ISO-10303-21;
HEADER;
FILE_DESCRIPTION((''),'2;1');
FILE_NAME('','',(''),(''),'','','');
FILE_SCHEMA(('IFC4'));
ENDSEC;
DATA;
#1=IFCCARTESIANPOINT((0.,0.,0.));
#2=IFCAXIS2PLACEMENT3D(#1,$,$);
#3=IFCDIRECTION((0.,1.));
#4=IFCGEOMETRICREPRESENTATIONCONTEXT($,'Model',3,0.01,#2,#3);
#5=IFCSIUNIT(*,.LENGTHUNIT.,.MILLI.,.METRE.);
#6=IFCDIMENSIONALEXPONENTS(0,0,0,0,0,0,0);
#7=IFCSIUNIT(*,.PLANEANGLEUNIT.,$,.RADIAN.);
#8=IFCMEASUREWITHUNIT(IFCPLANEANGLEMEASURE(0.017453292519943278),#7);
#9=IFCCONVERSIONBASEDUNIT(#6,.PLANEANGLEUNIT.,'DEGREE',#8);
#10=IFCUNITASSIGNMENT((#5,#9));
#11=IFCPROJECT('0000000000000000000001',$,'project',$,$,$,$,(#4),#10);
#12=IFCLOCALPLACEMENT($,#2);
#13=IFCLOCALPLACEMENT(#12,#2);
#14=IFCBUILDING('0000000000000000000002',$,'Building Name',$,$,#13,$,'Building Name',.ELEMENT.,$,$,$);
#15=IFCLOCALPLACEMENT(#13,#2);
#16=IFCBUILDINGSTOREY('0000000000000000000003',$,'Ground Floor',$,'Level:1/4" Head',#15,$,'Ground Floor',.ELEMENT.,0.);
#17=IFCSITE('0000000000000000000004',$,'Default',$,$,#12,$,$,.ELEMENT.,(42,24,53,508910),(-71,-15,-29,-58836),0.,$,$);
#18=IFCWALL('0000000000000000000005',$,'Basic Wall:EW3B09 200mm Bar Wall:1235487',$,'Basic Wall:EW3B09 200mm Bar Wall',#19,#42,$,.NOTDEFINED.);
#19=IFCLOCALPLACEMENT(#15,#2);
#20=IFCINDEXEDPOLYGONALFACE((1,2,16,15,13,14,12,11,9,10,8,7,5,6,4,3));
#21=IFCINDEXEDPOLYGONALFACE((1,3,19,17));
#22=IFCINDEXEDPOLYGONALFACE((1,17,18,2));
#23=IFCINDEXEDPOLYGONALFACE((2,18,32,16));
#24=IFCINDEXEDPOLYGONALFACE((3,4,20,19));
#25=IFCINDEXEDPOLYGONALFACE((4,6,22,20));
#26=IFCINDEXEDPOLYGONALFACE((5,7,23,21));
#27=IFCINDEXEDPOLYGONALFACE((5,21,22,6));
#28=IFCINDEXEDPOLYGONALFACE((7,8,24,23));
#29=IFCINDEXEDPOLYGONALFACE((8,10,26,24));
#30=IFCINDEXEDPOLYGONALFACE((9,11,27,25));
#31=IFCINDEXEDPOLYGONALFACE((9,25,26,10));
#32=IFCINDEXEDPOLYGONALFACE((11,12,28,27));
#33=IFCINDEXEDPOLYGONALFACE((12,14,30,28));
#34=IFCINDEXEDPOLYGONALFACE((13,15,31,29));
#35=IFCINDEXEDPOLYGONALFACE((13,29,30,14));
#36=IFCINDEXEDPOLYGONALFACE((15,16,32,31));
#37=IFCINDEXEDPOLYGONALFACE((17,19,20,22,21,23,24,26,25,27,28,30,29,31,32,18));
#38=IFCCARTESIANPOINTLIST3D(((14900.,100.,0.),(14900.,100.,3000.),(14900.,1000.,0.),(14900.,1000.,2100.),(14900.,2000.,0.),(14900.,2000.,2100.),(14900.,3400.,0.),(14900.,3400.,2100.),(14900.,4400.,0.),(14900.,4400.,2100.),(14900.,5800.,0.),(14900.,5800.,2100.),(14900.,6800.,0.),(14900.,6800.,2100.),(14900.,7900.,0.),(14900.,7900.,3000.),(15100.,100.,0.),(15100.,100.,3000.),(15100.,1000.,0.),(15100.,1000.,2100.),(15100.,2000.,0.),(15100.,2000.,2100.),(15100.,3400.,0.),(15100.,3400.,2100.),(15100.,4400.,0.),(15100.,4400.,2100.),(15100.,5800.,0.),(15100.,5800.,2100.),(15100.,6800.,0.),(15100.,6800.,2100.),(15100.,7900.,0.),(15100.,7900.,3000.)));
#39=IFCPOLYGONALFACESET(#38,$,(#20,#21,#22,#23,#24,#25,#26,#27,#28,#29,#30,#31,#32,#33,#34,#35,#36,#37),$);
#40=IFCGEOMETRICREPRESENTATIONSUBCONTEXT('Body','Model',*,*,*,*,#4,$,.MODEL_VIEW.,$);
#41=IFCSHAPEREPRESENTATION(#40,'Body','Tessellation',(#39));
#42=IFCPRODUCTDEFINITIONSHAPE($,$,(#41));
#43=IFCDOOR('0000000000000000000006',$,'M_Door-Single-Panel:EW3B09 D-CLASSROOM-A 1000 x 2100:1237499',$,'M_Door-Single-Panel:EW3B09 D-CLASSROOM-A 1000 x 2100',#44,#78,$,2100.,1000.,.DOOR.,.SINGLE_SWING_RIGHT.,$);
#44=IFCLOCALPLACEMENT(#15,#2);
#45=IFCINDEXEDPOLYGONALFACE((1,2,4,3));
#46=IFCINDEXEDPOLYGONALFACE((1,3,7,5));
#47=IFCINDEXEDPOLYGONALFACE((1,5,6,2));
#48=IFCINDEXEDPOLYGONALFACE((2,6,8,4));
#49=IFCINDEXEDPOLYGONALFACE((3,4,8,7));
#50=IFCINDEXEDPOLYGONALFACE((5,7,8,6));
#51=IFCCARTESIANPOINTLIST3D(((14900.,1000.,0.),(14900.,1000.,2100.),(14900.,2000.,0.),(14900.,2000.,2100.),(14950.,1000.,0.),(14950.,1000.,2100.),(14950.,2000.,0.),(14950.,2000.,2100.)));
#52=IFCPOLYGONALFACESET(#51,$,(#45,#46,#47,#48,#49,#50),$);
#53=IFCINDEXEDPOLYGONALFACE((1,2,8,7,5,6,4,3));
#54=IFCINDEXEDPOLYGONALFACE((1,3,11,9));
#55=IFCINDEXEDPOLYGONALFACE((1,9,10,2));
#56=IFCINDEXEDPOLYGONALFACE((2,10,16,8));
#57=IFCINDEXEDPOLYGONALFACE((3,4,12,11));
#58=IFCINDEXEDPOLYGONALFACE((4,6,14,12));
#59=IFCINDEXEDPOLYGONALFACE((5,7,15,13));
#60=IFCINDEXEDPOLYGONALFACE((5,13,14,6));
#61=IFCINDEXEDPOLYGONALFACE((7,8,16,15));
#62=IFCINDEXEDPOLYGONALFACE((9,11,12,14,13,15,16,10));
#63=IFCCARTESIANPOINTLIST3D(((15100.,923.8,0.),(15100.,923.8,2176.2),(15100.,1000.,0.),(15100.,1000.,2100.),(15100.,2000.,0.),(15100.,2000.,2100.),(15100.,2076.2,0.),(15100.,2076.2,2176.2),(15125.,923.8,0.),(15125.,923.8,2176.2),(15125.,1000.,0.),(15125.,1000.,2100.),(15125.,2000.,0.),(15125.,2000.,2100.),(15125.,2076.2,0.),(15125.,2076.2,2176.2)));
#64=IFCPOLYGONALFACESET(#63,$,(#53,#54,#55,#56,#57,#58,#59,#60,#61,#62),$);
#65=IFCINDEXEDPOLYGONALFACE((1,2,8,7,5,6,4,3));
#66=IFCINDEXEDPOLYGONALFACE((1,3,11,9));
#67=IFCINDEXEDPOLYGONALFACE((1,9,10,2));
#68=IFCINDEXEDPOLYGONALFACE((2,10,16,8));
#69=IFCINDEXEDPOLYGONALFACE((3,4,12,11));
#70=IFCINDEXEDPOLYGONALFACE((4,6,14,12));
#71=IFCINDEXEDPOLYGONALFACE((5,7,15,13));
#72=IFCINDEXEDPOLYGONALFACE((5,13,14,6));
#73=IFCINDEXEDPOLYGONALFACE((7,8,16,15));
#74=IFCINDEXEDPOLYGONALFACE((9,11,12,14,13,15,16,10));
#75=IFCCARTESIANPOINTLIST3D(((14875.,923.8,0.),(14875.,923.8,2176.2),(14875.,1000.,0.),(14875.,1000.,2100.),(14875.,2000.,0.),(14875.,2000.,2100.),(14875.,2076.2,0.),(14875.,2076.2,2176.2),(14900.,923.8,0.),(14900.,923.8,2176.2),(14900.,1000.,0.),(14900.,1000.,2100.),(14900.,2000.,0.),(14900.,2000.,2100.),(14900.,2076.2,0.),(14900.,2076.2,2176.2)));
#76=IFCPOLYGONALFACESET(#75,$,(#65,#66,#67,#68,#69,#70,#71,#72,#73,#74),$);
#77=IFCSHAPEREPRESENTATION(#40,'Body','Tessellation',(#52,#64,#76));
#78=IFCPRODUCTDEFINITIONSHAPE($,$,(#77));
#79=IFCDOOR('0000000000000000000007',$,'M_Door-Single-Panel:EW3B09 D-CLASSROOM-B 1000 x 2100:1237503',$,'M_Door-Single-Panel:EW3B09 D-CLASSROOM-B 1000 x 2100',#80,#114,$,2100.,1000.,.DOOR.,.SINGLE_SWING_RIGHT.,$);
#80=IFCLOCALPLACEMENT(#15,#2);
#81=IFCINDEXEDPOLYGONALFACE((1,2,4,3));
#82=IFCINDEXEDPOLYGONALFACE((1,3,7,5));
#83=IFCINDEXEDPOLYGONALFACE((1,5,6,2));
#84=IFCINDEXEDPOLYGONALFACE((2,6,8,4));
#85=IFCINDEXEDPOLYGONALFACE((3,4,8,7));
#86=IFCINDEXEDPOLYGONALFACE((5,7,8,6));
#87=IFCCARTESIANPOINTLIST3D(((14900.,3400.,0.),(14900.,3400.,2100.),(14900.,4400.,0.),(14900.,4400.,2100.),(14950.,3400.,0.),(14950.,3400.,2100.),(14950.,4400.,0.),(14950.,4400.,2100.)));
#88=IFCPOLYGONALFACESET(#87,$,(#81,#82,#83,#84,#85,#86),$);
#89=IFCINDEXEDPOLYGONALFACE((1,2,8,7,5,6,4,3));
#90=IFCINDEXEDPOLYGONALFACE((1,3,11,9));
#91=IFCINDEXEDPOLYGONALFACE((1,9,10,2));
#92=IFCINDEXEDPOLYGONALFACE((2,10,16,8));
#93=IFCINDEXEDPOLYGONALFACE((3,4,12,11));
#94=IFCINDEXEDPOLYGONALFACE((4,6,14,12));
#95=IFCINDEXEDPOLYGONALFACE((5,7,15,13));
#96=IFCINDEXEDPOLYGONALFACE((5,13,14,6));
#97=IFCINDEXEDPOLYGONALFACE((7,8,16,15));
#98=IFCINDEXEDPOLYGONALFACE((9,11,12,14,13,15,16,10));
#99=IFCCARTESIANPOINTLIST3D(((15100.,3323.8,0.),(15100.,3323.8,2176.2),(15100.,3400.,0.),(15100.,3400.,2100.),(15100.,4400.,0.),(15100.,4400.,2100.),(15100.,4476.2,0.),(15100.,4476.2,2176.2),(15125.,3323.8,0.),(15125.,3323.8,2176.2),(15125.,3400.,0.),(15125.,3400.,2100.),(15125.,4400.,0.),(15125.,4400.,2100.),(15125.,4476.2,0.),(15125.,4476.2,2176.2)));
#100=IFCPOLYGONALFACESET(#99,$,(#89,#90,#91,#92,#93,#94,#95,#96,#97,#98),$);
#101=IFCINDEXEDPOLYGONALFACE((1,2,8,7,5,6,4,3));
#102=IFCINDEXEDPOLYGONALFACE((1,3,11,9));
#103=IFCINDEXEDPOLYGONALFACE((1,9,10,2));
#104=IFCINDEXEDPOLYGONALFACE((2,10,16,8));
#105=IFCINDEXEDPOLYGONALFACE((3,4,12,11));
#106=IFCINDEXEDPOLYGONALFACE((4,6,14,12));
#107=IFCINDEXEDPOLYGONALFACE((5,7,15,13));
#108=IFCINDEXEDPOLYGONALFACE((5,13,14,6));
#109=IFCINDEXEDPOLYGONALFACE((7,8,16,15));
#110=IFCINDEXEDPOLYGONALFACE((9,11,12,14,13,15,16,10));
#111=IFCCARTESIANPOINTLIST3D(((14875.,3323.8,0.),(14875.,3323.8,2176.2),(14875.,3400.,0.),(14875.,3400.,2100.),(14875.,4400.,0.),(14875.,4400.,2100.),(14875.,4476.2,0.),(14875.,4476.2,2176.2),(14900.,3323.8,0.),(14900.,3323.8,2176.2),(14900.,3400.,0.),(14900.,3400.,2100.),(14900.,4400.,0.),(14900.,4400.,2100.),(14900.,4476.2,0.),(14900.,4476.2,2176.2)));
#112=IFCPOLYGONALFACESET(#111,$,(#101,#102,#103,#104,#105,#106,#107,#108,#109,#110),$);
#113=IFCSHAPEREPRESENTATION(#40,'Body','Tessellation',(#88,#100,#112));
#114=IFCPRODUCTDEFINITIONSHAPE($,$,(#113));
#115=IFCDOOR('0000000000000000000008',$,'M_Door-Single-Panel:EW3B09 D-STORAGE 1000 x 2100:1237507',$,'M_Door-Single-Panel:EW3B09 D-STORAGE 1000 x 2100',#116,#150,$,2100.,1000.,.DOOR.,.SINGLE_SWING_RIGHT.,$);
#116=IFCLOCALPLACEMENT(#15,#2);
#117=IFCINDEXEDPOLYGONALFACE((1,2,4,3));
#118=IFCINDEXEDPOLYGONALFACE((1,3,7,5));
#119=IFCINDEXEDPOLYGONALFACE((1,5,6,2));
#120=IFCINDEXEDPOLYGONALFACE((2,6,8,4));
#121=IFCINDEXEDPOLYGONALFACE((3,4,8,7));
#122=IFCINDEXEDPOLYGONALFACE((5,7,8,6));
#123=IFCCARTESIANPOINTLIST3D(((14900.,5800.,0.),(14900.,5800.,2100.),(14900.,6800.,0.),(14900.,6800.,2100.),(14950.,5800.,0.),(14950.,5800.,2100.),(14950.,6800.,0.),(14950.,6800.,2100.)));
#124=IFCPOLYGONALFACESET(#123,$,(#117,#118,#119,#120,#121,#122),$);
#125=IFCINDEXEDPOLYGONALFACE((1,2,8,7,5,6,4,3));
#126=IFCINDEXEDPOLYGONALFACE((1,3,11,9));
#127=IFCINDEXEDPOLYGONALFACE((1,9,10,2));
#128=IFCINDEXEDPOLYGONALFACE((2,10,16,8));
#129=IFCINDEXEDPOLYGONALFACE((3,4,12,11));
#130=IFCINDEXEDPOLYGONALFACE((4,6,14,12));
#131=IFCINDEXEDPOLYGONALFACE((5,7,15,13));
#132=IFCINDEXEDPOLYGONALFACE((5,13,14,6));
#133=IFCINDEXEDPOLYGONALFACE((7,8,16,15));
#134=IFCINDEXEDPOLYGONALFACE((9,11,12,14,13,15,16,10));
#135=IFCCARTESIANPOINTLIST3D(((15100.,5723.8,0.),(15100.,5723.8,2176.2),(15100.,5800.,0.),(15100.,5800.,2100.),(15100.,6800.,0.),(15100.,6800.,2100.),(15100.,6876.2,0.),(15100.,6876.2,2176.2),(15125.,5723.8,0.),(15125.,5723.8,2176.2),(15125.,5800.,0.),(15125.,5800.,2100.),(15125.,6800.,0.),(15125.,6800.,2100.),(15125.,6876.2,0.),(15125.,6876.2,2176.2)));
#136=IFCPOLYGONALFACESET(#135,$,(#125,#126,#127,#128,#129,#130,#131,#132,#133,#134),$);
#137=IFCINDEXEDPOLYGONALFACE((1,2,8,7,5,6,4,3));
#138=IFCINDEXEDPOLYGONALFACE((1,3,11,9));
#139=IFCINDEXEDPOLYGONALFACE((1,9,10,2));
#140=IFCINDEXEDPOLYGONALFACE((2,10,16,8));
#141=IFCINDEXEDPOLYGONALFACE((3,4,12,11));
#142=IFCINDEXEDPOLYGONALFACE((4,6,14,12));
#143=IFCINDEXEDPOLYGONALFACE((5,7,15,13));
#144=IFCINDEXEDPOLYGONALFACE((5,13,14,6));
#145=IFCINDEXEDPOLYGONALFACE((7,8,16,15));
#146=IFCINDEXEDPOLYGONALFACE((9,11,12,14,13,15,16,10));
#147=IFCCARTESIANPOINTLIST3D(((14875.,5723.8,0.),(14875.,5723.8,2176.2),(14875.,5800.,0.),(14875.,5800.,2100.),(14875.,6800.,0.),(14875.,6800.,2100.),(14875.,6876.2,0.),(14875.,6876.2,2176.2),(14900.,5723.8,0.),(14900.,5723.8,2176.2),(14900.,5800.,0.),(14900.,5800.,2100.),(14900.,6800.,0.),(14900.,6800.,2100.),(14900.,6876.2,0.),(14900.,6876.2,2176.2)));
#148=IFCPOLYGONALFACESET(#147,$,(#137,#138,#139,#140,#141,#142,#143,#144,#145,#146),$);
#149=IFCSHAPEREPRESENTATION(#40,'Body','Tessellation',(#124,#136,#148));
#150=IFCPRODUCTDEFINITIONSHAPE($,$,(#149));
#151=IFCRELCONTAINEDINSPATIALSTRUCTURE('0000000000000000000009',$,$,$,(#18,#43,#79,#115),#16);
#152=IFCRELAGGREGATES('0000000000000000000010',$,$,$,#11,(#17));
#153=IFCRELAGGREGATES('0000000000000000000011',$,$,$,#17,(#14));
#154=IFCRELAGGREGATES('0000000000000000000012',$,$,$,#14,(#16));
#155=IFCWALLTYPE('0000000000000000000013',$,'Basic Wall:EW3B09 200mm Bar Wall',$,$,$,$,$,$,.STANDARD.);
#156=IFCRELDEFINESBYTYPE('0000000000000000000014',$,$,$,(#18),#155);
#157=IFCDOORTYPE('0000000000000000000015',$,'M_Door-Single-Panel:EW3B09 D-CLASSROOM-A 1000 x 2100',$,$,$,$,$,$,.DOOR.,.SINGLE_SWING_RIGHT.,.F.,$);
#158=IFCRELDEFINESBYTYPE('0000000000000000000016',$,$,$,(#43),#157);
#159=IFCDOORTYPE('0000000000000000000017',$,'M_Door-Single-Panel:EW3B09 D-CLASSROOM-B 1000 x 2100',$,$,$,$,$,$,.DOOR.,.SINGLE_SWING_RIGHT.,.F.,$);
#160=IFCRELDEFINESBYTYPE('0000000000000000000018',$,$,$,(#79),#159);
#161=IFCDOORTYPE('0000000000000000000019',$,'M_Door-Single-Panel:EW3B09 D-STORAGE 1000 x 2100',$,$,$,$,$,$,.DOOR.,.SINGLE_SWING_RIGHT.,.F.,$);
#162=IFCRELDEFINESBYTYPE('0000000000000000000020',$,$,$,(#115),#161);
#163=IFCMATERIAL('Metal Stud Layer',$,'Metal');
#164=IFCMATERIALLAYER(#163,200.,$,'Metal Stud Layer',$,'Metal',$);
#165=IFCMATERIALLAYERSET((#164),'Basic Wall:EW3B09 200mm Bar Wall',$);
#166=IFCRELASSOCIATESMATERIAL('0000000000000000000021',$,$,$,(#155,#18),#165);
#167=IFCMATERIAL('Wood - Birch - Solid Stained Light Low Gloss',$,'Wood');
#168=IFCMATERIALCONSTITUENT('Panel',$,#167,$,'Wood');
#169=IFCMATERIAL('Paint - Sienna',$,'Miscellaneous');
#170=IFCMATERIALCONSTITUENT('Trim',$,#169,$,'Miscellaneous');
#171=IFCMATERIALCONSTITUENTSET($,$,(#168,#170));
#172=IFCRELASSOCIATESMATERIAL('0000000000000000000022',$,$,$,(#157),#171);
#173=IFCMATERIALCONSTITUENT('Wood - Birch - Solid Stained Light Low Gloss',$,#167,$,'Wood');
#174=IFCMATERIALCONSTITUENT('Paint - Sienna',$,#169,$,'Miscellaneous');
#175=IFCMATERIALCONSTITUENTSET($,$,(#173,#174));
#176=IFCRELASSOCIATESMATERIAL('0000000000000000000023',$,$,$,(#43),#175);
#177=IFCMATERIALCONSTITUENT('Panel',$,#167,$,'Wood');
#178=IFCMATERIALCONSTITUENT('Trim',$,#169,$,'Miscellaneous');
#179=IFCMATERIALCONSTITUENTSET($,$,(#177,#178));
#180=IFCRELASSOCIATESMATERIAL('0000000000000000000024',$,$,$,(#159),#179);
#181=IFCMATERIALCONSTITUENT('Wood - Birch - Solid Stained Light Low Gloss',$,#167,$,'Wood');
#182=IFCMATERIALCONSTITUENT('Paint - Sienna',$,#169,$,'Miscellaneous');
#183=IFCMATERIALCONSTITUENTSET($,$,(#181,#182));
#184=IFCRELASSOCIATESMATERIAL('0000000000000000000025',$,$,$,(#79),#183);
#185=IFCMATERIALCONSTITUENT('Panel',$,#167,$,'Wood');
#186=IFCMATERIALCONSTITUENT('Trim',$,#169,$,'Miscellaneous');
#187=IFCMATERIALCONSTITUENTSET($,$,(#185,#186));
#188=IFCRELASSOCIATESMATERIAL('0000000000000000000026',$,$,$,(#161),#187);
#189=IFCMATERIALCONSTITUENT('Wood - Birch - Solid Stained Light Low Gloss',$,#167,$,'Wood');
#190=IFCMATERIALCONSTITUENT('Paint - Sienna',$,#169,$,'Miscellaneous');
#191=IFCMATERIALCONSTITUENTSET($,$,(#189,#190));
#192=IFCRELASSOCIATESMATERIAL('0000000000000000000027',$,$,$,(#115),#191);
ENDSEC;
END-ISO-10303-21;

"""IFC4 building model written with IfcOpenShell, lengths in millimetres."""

from ifc_helpers import new_model, entity, si_unit, converted_unit, direction, frame, frame_2d, origin, place, context, subcontext, project, spatial, polyline, rectangle, outline, extrude, source, transform, mapped, material, layer, layer_set, layer_usage, constituent, constituent_set, type_object, type_shapes, element, fill, save


model = new_model("IFC4")

# Units and contexts
model_context = context("Model", 3, precision=0.01, world=origin(), true_north=direction((0.0, 1.0)))
body_context = subcontext(model_context, "Body", "Model", "MODEL_VIEW")
ifc_project = project(units=[si_unit("LENGTHUNIT", "METRE", prefix="MILLI"), converted_unit("PLANEANGLEUNIT", "DEGREE", entity("IfcPlaneAngleMeasure", 0.017453292519943278), si_unit("PLANEANGLEUNIT", "RADIAN"), dimensions=[0, 0, 0, 0, 0, 0, 0])], contexts=[model_context])

# Site, building, storey
site_placement = place(None, origin())
site = spatial("IfcSite", under=ifc_project, at=site_placement, Name="Default", CompositionType="ELEMENT", RefLatitude=(42, 24, 53, 508910), RefLongitude=(-71, -15, -29, -58836), RefElevation=0.0)
building_placement = place(site_placement, origin())
building = spatial("IfcBuilding", under=site, at=building_placement, Name="Building Name", LongName="Building Name", CompositionType="ELEMENT")
storey_placement = place(building_placement, origin())
storey = spatial("IfcBuildingStorey", under=building, at=storey_placement, Name="Ground Floor", ObjectType="Level:1/4\" Head", LongName="Ground Floor", CompositionType="ELEMENT", Elevation=0.0)

# Shared definitions
ifc_material_1 = material(Name="Metal Stud Layer", Category="Metal")
ifc_layer_1 = layer(ifc_material_1, 200.0, Name="Metal Stud Layer", Category="Metal")
ifc_layer_set_1 = layer_set([ifc_layer_1], Name="Basic Wall:EW3B09 200mm Bar Wall")
wall_type = type_object("IfcWallType", Name="Basic Wall:EW3B09 200mm Bar Wall", PredefinedType="STANDARD", material=ifc_layer_set_1)
ifc_material_2 = material(Name="Wood - Birch - Solid Stained Light Low Gloss", Category="Wood")
ifc_material_3 = material(Name="Paint - Sienna", Category="Miscellaneous")

# Wall, openings, doors
ifc_layer_usage_1 = layer_usage(ifc_layer_set_1, "AXIS2", "NEGATIVE", 100.0)
wall_1_placement = place(storey_placement, frame((15000.0, 100.0, 0.0), z_axis=(0.0, 0.0, 1.0), x_axis=(0.0, 1.0, 0.0)))
wall_1 = element("IfcWall", 1, at=wall_1_placement, inside=storey, type_object=wall_type, material=ifc_layer_usage_1, Name="Basic Wall:EW3B09 200mm Bar Wall:1235487", ObjectType="Basic Wall:EW3B09 200mm Bar Wall", PredefinedType="NOTDEFINED", context=body_context, shape_type="SweptSolid", body=[
    extrude(rectangle(XDim=7800.0, YDim=200.0, at=frame_2d((3900.0, 0.0), x_axis=(1.0, 0.0))), origin(), (0.0, 0.0, 1.0), 3000.0),
])
opening_1_placement = place(wall_1_placement, frame((900.0, -100.0, 0.0)))
opening_1 = element("IfcOpeningElement", 2, at=opening_1_placement, cuts=wall_1, PredefinedType="OPENING", context=body_context, shape_type="SweptSolid", body=[
    extrude(rectangle(XDim=1000.0, YDim=2100.0, at=frame_2d((1050.0, 500.0), x_axis=(0.0, 1.0))), frame((0.0, 0.0, 0.0), z_axis=(0.0, 1.0, 0.0), x_axis=(0.0, 0.0, 1.0)), (0.0, 0.0, 1.0), 200.0),
])
opening_2_placement = place(wall_1_placement, frame((3300.0, -100.0, 0.0)))
opening_2 = element("IfcOpeningElement", 3, at=opening_2_placement, cuts=wall_1, PredefinedType="OPENING", context=body_context, shape_type="SweptSolid", body=[
    extrude(rectangle(XDim=1000.0, YDim=2100.0, at=frame_2d((1050.0, 500.0), x_axis=(0.0, 1.0))), frame((0.0, 0.0, 0.0), z_axis=(0.0, 1.0, 0.0), x_axis=(0.0, 0.0, 1.0)), (0.0, 0.0, 1.0), 200.0),
])
opening_3_placement = place(wall_1_placement, frame((5700.0, -100.0, 0.0)))
opening_3 = element("IfcOpeningElement", 4, at=opening_3_placement, cuts=wall_1, PredefinedType="OPENING", context=body_context, shape_type="SweptSolid", body=[
    extrude(rectangle(XDim=1000.0, YDim=2100.0, at=frame_2d((1050.0, 500.0), x_axis=(0.0, 1.0))), frame((0.0, 0.0, 0.0), z_axis=(0.0, 1.0, 0.0), x_axis=(0.0, 0.0, 1.0)), (0.0, 0.0, 1.0), 200.0),
])
ifc_constituent_1 = constituent(ifc_material_2, Name="Wood - Birch - Solid Stained Light Low Gloss", Category="Wood")
ifc_constituent_2 = constituent(ifc_material_3, Name="Paint - Sienna", Category="Miscellaneous")
ifc_constituent_set_1 = constituent_set(constituents=[ifc_constituent_1, ifc_constituent_2])
ifc_constituent_3 = constituent(ifc_material_2, Name="Panel", Category="Wood")
ifc_constituent_4 = constituent(ifc_material_3, Name="Trim", Category="Miscellaneous")
ifc_constituent_set_2 = constituent_set(constituents=[ifc_constituent_3, ifc_constituent_4])
door_type_1 = type_object("IfcDoorType", Name="M_Door-Single-Panel:EW3B09 D-CLASSROOM-A 1000 x 2100", OperationType="SINGLE_SWING_RIGHT", ParameterTakesPrecedence=False, PredefinedType="DOOR", material=ifc_constituent_set_2)
shared_shape_1 = source(origin(), body_context, "Body", "SweptSolid", [
    extrude(rectangle(XDim=50.0, YDim=1000.0, at=frame_2d((0.0, 0.0), x_axis=(1.0, 0.0))), frame((500.0, 175.0, 0.0), z_axis=(0.0, 0.0, 1.0), x_axis=(0.0, 1.0, 0.0)), (0.0, 0.0, 1.0), 2100.0),
    extrude(outline(polyline([(-1107.1, -576.2), (1069.0, -576.2), (1069.0, -500.0), (-1030.9, -500.0), (-1030.9, 500.0), (1069.0, 500.0), (1069.0, 576.2), (-1107.1, 576.2), (-1107.1, -576.2)])), frame((500.0, -25.0, 1069.0), z_axis=(0.0, 1.0, 0.0), x_axis=(0.0, 0.0, -1.0)), (0.0, 0.0, 1.0), 25.0),
    extrude(outline(polyline([(-576.2, -1107.1), (576.2, -1107.1), (576.2, 1069.1), (500.0, 1069.1), (500.0, -1031.0), (-500.0, -1031.0), (-500.0, 1069.1), (-576.2, 1069.1), (-576.2, -1107.1)])), frame((500.0, 200.0, 1069.1), z_axis=(0.0, 1.0, 0.0), x_axis=(1.0, 0.0, 0.0)), (0.0, 0.0, 1.0), 25.0),
])
type_shapes(door_type_1, [shared_shape_1])
door_1_placement = place(opening_1_placement, origin())
door_1 = element("IfcDoor", 5, at=door_1_placement, inside=storey, type_object=door_type_1, material=ifc_constituent_set_1, Name="M_Door-Single-Panel:EW3B09 D-CLASSROOM-A 1000 x 2100:1237499", ObjectType="M_Door-Single-Panel:EW3B09 D-CLASSROOM-A 1000 x 2100", OperationType="SINGLE_SWING_RIGHT", OverallHeight=2100.0, OverallWidth=1000.0, PredefinedType="DOOR", context=body_context, shape_type="MappedRepresentation", body=[
    mapped(shared_shape_1, transform((0.0, 0.0, 0.0), scale=1.0)),
])
fill(opening_1, door_1)
ifc_constituent_5 = constituent(ifc_material_2, Name="Wood - Birch - Solid Stained Light Low Gloss", Category="Wood")
ifc_constituent_6 = constituent(ifc_material_3, Name="Paint - Sienna", Category="Miscellaneous")
ifc_constituent_set_3 = constituent_set(constituents=[ifc_constituent_5, ifc_constituent_6])
ifc_constituent_7 = constituent(ifc_material_2, Name="Panel", Category="Wood")
ifc_constituent_8 = constituent(ifc_material_3, Name="Trim", Category="Miscellaneous")
ifc_constituent_set_4 = constituent_set(constituents=[ifc_constituent_7, ifc_constituent_8])
door_type_2 = type_object("IfcDoorType", Name="M_Door-Single-Panel:EW3B09 D-CLASSROOM-B 1000 x 2100", OperationType="SINGLE_SWING_RIGHT", ParameterTakesPrecedence=False, PredefinedType="DOOR", material=ifc_constituent_set_4)
shared_shape_2 = source(origin(), body_context, "Body", "SweptSolid", [
    extrude(rectangle(XDim=50.0, YDim=1000.0, at=frame_2d((0.0, 0.0), x_axis=(1.0, 0.0))), frame((500.0, 175.0, 0.0), z_axis=(0.0, 0.0, 1.0), x_axis=(0.0, 1.0, 0.0)), (0.0, 0.0, 1.0), 2100.0),
    extrude(outline(polyline([(-1107.1, -576.2), (1069.0, -576.2), (1069.0, -500.0), (-1030.9, -500.0), (-1030.9, 500.0), (1069.0, 500.0), (1069.0, 576.2), (-1107.1, 576.2), (-1107.1, -576.2)])), frame((500.0, -25.0, 1069.0), z_axis=(0.0, 1.0, 0.0), x_axis=(0.0, 0.0, -1.0)), (0.0, 0.0, 1.0), 25.0),
    extrude(outline(polyline([(-576.2, -1107.1), (576.2, -1107.1), (576.2, 1069.1), (500.0, 1069.1), (500.0, -1031.0), (-500.0, -1031.0), (-500.0, 1069.1), (-576.2, 1069.1), (-576.2, -1107.1)])), frame((500.0, 200.0, 1069.1), z_axis=(0.0, 1.0, 0.0), x_axis=(1.0, 0.0, 0.0)), (0.0, 0.0, 1.0), 25.0),
])
type_shapes(door_type_2, [shared_shape_2])
door_2_placement = place(opening_2_placement, origin())
door_2 = element("IfcDoor", 6, at=door_2_placement, inside=storey, type_object=door_type_2, material=ifc_constituent_set_3, Name="M_Door-Single-Panel:EW3B09 D-CLASSROOM-B 1000 x 2100:1237503", ObjectType="M_Door-Single-Panel:EW3B09 D-CLASSROOM-B 1000 x 2100", OperationType="SINGLE_SWING_RIGHT", OverallHeight=2100.0, OverallWidth=1000.0, PredefinedType="DOOR", context=body_context, shape_type="MappedRepresentation", body=[
    mapped(shared_shape_2, transform((0.0, 0.0, 0.0), scale=1.0)),
])
fill(opening_2, door_2)
ifc_constituent_9 = constituent(ifc_material_2, Name="Wood - Birch - Solid Stained Light Low Gloss", Category="Wood")
ifc_constituent_10 = constituent(ifc_material_3, Name="Paint - Sienna", Category="Miscellaneous")
ifc_constituent_set_5 = constituent_set(constituents=[ifc_constituent_9, ifc_constituent_10])
ifc_constituent_11 = constituent(ifc_material_2, Name="Panel", Category="Wood")
ifc_constituent_12 = constituent(ifc_material_3, Name="Trim", Category="Miscellaneous")
ifc_constituent_set_6 = constituent_set(constituents=[ifc_constituent_11, ifc_constituent_12])
door_type_3 = type_object("IfcDoorType", Name="M_Door-Single-Panel:EW3B09 D-STORAGE 1000 x 2100", OperationType="SINGLE_SWING_RIGHT", ParameterTakesPrecedence=False, PredefinedType="DOOR", material=ifc_constituent_set_6)
shared_shape_3 = source(origin(), body_context, "Body", "SweptSolid", [
    extrude(rectangle(XDim=50.0, YDim=1000.0, at=frame_2d((0.0, 0.0), x_axis=(1.0, 0.0))), frame((500.0, 175.0, 0.0), z_axis=(0.0, 0.0, 1.0), x_axis=(0.0, 1.0, 0.0)), (0.0, 0.0, 1.0), 2100.0),
    extrude(outline(polyline([(-1107.1, -576.2), (1069.0, -576.2), (1069.0, -500.0), (-1030.9, -500.0), (-1030.9, 500.0), (1069.0, 500.0), (1069.0, 576.2), (-1107.1, 576.2), (-1107.1, -576.2)])), frame((500.0, -25.0, 1069.0), z_axis=(0.0, 1.0, 0.0), x_axis=(0.0, 0.0, -1.0)), (0.0, 0.0, 1.0), 25.0),
    extrude(outline(polyline([(-576.2, -1107.1), (576.2, -1107.1), (576.2, 1069.1), (500.0, 1069.1), (500.0, -1031.0), (-500.0, -1031.0), (-500.0, 1069.1), (-576.2, 1069.1), (-576.2, -1107.1)])), frame((500.0, 200.0, 1069.1), z_axis=(0.0, 1.0, 0.0), x_axis=(1.0, 0.0, 0.0)), (0.0, 0.0, 1.0), 25.0),
])
type_shapes(door_type_3, [shared_shape_3])
door_3_placement = place(opening_3_placement, origin())
door_3 = element("IfcDoor", 7, at=door_3_placement, inside=storey, type_object=door_type_3, material=ifc_constituent_set_5, Name="M_Door-Single-Panel:EW3B09 D-STORAGE 1000 x 2100:1237507", ObjectType="M_Door-Single-Panel:EW3B09 D-STORAGE 1000 x 2100", OperationType="SINGLE_SWING_RIGHT", OverallHeight=2100.0, OverallWidth=1000.0, PredefinedType="DOOR", context=body_context, shape_type="MappedRepresentation", body=[
    mapped(shared_shape_3, transform((0.0, 0.0, 0.0), scale=1.0)),
])
fill(opening_3, door_3)

save(model, "model.ifc")
